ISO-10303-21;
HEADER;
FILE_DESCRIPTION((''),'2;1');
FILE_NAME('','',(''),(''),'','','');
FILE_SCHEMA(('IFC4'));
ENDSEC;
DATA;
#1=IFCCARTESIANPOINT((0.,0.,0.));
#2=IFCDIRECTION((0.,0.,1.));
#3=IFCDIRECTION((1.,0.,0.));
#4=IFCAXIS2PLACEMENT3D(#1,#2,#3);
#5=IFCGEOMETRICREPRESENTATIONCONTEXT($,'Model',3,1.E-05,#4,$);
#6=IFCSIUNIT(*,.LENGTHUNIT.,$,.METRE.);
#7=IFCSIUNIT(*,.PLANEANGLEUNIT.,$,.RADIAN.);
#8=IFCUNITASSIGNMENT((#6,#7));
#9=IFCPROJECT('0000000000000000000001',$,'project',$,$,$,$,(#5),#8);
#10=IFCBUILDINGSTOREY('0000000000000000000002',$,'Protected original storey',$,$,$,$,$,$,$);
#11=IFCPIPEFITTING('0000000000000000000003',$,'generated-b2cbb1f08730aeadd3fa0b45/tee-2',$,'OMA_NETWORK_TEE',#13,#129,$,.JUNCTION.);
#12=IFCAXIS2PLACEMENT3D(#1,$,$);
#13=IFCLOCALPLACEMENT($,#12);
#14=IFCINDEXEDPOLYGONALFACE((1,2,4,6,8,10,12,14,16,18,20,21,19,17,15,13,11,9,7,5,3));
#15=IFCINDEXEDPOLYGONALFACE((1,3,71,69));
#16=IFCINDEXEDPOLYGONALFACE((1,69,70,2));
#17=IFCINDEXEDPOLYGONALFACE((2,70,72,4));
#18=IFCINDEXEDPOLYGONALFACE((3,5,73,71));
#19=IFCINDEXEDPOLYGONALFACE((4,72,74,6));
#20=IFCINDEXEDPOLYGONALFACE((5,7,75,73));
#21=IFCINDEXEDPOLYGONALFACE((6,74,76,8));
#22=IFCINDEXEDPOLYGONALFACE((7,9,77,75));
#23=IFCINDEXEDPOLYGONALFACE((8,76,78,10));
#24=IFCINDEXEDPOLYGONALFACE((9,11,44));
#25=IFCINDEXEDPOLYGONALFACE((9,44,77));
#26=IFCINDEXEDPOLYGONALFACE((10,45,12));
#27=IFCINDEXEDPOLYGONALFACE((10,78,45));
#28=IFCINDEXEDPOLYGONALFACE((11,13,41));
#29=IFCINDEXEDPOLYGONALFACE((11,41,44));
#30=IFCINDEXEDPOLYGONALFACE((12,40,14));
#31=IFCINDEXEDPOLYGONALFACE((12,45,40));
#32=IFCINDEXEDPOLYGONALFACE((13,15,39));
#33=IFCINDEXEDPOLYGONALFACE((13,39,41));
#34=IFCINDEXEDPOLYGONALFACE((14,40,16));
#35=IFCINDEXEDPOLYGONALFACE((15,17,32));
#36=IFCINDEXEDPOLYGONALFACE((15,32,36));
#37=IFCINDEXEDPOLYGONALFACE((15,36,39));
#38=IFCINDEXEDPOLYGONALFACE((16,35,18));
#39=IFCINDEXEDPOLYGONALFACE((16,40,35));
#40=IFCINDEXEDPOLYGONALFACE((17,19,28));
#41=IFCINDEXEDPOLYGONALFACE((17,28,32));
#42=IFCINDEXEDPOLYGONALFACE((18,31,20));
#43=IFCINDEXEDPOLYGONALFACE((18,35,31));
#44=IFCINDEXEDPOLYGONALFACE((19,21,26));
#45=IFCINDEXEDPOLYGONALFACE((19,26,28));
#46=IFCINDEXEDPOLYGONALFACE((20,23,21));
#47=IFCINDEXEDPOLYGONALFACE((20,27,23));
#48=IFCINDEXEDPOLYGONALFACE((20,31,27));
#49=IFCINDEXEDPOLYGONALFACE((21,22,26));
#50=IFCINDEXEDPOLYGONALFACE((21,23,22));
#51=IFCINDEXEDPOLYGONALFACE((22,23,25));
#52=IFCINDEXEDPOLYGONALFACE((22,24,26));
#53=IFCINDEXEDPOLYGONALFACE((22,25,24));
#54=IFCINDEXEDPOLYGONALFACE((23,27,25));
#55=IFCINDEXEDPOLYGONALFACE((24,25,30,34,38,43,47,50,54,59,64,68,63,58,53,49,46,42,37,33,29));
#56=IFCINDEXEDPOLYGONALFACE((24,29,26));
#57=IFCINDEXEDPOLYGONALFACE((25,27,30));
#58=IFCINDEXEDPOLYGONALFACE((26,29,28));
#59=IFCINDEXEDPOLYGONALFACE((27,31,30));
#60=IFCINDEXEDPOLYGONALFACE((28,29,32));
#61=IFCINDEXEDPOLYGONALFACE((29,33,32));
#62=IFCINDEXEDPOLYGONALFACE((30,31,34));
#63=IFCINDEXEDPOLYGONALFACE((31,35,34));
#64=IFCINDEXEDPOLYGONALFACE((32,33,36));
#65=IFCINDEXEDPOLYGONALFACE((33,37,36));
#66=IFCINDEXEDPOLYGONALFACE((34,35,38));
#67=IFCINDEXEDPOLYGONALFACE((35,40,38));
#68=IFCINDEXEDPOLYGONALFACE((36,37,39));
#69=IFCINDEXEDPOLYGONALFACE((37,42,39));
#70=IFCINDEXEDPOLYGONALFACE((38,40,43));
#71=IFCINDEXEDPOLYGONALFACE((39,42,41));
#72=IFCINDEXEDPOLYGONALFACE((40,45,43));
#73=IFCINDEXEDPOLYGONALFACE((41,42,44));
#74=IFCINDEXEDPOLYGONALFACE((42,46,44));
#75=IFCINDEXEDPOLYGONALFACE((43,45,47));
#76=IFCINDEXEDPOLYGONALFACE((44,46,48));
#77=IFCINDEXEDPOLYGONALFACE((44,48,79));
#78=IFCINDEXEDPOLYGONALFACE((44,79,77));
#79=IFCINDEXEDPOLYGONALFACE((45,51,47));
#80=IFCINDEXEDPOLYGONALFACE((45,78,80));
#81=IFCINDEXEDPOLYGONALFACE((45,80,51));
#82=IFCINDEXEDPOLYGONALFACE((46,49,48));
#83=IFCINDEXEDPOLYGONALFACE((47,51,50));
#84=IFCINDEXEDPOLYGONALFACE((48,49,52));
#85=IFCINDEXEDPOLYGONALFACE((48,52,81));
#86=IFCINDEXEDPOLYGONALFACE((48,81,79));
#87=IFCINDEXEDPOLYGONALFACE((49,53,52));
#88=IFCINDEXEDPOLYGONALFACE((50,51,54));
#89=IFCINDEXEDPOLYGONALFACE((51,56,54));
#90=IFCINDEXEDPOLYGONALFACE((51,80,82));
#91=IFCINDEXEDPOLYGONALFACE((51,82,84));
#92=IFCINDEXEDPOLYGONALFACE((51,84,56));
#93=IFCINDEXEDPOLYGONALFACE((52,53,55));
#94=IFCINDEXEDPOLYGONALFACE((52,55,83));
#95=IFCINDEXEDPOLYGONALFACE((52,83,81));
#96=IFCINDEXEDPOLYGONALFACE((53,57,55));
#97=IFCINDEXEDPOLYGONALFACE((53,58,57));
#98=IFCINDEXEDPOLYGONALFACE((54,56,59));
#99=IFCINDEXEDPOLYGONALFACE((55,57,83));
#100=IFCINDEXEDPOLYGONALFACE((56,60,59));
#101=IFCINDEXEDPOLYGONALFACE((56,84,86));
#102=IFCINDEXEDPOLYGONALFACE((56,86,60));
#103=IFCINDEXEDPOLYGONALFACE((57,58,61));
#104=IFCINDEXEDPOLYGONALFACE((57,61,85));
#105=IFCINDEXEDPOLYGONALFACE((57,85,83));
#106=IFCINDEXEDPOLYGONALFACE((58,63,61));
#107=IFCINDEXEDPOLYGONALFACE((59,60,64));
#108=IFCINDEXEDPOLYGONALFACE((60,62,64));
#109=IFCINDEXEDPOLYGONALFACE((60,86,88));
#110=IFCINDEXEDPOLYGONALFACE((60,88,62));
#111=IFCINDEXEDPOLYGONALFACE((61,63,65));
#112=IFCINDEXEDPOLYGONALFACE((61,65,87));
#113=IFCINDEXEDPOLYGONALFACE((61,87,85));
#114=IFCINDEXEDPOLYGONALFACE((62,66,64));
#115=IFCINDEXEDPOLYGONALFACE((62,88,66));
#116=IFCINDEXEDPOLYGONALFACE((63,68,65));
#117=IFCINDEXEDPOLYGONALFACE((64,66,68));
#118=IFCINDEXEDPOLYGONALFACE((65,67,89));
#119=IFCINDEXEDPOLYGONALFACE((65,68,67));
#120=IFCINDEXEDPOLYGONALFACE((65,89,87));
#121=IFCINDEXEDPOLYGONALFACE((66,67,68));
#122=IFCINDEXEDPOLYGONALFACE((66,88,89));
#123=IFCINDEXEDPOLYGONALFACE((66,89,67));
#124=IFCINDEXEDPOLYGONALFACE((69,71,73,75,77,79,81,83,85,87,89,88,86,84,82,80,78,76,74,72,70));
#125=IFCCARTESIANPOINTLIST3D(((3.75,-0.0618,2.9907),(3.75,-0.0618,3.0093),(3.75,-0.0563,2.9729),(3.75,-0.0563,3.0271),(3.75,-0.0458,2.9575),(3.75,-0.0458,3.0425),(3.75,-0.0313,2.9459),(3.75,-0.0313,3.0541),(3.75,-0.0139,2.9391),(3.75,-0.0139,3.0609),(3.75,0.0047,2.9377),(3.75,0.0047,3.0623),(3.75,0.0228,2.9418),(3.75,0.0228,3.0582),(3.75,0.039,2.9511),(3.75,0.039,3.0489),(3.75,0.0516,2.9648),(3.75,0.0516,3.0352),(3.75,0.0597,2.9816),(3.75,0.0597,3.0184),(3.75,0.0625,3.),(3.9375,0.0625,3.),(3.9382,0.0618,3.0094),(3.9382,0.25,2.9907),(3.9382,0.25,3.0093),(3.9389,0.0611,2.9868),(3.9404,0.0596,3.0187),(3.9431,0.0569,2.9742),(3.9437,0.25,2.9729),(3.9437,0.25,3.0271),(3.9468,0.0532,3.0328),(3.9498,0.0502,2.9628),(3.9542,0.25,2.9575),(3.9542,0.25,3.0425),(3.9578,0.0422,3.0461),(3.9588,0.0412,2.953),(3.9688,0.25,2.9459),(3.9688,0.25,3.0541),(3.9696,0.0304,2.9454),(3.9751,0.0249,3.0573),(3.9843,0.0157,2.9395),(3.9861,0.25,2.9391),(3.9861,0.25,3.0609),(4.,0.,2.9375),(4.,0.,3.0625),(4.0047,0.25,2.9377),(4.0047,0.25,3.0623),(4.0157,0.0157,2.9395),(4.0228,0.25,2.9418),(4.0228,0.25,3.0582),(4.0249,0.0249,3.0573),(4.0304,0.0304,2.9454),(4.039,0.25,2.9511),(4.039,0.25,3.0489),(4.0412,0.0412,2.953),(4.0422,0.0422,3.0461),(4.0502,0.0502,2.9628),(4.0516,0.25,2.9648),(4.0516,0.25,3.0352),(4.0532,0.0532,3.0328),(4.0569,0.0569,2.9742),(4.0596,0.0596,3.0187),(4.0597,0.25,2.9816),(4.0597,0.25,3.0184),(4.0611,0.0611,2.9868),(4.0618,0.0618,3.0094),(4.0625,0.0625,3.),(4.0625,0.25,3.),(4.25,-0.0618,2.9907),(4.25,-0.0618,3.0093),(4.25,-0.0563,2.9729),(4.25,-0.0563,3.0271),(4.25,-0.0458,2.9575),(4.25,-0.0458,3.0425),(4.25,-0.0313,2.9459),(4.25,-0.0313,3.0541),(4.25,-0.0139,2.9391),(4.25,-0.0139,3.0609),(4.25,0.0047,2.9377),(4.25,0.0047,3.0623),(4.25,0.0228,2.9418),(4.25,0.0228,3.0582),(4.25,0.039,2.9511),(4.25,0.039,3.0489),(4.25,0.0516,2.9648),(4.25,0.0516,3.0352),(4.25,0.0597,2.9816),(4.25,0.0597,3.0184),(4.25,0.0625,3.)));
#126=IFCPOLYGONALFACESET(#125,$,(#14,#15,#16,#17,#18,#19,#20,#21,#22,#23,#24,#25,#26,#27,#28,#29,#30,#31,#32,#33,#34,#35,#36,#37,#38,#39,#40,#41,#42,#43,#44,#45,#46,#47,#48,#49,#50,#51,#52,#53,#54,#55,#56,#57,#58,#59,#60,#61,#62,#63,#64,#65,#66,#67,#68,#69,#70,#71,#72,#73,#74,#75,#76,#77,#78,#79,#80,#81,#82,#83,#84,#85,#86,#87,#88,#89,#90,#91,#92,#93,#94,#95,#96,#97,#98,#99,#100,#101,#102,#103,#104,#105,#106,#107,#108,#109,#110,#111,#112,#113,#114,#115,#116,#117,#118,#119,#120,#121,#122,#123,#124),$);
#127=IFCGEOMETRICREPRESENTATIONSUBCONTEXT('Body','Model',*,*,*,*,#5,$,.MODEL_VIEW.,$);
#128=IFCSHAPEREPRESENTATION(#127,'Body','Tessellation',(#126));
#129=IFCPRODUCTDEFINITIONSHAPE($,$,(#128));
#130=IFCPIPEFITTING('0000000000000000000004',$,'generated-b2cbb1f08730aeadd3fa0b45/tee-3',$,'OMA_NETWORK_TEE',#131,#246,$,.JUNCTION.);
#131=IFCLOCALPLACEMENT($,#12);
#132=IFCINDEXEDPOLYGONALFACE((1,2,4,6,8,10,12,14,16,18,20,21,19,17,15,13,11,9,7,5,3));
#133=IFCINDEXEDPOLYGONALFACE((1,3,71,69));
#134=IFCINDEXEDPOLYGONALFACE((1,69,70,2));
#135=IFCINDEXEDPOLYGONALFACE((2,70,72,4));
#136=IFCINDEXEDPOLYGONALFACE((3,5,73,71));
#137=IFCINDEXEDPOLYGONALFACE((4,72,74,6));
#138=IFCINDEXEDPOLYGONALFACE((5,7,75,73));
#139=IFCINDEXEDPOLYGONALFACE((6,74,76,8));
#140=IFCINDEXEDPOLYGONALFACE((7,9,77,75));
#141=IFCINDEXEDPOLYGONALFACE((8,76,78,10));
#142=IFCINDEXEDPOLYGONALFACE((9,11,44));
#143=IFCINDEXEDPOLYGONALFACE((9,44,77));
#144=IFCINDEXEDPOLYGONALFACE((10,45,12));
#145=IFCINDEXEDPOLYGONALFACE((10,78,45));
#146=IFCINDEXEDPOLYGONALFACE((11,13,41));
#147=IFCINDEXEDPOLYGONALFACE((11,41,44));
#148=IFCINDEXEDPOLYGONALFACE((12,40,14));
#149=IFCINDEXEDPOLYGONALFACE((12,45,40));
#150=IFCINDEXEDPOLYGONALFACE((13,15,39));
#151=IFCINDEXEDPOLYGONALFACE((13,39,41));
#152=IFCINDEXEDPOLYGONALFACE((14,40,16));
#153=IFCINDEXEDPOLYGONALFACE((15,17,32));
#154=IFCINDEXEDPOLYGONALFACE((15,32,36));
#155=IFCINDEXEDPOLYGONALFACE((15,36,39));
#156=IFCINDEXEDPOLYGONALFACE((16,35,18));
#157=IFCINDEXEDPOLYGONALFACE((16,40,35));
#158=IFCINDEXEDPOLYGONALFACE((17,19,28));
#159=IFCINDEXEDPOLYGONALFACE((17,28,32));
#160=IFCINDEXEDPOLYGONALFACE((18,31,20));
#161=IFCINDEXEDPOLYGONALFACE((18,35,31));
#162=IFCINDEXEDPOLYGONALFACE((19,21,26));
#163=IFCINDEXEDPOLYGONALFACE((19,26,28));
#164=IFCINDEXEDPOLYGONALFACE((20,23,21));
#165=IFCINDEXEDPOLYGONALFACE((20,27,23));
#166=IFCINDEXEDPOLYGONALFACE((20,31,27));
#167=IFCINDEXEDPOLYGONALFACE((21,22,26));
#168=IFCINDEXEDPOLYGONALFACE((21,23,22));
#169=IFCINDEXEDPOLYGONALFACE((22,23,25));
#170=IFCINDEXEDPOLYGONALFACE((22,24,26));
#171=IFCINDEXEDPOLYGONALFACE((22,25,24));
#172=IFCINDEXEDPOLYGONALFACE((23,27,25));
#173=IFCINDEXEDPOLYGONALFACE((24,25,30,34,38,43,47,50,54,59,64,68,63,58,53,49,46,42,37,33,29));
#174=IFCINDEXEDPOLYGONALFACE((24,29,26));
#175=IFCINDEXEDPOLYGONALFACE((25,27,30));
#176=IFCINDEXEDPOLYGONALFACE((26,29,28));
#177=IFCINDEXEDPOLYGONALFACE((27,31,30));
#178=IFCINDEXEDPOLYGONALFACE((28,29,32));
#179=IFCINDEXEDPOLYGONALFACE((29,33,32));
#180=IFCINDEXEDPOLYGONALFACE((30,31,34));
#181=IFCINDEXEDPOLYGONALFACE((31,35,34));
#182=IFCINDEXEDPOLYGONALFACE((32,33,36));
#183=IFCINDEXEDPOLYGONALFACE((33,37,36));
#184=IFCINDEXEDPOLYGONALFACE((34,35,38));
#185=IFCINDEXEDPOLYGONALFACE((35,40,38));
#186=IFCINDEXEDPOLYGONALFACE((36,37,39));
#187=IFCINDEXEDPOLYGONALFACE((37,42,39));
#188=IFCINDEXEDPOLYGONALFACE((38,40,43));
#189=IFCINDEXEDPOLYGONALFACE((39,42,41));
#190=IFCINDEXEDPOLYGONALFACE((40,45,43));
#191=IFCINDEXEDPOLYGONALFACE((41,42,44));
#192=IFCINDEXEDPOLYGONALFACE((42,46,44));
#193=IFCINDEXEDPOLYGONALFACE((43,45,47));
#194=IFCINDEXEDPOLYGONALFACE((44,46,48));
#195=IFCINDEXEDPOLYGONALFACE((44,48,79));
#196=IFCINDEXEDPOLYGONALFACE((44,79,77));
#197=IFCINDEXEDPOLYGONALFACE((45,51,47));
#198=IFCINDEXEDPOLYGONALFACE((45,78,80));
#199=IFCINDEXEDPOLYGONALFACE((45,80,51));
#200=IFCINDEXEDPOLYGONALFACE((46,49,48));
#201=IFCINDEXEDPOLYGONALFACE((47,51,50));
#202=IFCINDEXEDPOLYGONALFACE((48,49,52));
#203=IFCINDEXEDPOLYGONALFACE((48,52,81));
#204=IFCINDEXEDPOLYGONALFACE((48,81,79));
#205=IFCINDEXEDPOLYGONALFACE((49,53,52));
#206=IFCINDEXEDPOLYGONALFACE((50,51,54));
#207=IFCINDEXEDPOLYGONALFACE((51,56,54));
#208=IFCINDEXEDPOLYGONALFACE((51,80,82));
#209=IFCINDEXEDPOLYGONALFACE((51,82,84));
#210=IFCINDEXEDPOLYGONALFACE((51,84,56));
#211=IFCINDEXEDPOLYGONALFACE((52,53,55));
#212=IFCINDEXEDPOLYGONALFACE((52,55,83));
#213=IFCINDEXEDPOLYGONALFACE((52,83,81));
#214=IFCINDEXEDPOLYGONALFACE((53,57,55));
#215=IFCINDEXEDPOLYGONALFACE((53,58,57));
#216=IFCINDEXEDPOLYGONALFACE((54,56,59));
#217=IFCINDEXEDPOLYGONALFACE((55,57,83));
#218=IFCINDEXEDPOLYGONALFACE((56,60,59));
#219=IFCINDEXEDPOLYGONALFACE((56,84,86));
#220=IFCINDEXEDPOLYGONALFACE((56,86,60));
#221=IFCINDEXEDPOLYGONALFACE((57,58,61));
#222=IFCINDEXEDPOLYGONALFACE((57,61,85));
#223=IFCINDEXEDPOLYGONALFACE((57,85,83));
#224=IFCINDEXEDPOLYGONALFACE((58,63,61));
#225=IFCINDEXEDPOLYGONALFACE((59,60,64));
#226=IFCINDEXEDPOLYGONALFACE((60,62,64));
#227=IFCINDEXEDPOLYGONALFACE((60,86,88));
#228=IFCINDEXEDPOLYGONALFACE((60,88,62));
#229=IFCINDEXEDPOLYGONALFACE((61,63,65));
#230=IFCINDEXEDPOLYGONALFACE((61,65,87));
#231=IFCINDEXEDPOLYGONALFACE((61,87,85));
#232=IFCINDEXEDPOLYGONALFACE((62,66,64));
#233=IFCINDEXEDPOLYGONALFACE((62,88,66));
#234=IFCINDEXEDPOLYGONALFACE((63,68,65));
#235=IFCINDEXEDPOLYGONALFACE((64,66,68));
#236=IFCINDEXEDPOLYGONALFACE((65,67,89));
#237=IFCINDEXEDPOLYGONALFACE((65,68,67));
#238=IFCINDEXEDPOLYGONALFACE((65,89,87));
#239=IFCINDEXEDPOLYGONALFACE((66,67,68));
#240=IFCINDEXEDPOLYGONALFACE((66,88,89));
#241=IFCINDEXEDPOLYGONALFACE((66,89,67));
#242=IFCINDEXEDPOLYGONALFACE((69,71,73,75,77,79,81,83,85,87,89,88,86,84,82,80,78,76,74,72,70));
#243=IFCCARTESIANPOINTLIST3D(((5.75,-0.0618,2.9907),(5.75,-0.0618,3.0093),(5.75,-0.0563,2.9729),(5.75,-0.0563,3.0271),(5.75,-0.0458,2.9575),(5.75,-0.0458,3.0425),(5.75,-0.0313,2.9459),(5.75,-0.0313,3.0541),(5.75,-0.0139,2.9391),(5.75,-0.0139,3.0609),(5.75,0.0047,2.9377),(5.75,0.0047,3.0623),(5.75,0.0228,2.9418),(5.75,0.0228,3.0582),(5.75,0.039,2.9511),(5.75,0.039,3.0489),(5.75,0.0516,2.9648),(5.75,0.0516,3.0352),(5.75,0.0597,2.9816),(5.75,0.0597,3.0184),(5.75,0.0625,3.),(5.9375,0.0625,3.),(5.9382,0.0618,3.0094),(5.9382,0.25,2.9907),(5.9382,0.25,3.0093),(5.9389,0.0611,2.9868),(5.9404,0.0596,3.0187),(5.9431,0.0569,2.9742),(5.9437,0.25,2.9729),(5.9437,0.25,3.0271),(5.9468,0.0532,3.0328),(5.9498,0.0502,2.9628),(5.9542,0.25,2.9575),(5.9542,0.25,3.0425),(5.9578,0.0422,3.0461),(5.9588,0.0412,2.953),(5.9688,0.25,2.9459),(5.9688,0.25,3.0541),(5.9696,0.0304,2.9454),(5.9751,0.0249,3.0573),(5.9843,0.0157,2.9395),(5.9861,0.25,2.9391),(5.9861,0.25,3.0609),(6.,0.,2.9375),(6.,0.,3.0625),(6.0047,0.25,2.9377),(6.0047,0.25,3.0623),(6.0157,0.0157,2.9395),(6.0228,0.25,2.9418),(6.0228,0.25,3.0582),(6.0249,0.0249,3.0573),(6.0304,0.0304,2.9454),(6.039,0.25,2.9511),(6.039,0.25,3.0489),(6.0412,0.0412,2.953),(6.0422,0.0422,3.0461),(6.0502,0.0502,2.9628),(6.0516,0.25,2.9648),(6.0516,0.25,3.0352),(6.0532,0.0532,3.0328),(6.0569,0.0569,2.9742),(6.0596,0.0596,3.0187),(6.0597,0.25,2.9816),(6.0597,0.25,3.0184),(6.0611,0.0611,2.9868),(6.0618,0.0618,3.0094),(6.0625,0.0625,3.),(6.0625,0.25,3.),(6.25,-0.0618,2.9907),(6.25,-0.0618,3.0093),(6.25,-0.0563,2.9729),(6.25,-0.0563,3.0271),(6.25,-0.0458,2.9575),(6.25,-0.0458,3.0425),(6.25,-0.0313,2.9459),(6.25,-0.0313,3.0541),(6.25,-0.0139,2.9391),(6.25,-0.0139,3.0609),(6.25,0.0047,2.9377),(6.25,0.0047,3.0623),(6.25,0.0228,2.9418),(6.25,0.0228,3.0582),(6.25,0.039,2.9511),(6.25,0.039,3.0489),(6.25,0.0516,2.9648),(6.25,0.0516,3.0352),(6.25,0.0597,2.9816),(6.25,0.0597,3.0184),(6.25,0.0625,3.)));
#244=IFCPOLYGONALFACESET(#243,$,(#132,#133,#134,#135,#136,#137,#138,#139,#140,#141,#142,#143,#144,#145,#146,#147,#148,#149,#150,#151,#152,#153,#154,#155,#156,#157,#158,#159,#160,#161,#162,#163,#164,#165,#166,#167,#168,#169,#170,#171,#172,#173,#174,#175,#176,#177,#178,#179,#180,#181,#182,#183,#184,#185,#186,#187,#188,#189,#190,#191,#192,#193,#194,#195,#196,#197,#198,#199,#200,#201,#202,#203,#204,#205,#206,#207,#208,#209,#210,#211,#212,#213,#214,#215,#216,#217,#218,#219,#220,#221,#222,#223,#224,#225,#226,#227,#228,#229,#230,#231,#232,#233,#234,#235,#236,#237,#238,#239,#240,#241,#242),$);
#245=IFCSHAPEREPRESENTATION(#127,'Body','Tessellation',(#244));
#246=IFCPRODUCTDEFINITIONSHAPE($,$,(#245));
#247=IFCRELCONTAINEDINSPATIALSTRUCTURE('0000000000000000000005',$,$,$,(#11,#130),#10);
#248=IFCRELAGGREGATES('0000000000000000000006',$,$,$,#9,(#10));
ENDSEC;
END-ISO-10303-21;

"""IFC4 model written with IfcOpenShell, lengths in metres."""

from ifc_helpers import new_model, si_unit, frame, origin_with_axes, origin_2d, place, context, subcontext, project, spatial, circle, extrude, boolean, element, save


model = new_model("IFC4")

# Units and contexts
model_context = context("Model", 3, precision=1e-05, world=origin_with_axes())
body_context = subcontext(model_context, "Body", "Model", "MODEL_VIEW")
ifc_project = project(units=[si_unit("LENGTHUNIT", "METRE"), si_unit("PLANEANGLEUNIT", "RADIAN")], contexts=[model_context])

# Storey
storey = spatial("IfcBuildingStorey", under=ifc_project, Name="Protected original storey")

# Pipe fittings
pipe_fitting_1_placement = place(None, origin_with_axes())
element("IfcPipeFitting", 1, at=pipe_fitting_1_placement, inside=storey, Name="generated-b2cbb1f08730aeadd3fa0b45/tee-2", ObjectType="OMA_NETWORK_TEE", PredefinedType="JUNCTION", context=body_context, shape_type="CSG", body=[
    boolean("UNION", extrude(circle(Radius=0.0625, at=origin_2d()), frame((3.75, 0.0, 3.0), z_axis=(1.0, 0.0, 0.0), x_axis=(0.0, 1.0, 0.0)), (0.0, 0.0, 1.0), 0.5), extrude(circle(Radius=0.0625, at=origin_2d()), frame((4.0, 0.0, 3.0), z_axis=(0.0, 1.0, 0.0), x_axis=(1.0, 0.0, 0.0)), (0.0, 0.0, 1.0), 0.25)),
])
pipe_fitting_2_placement = place(None, origin_with_axes())
element("IfcPipeFitting", 2, at=pipe_fitting_2_placement, inside=storey, Name="generated-b2cbb1f08730aeadd3fa0b45/tee-3", ObjectType="OMA_NETWORK_TEE", PredefinedType="JUNCTION", context=body_context, shape_type="CSG", body=[
    boolean("UNION", extrude(circle(Radius=0.0625, at=origin_2d()), frame((5.75, 0.0, 3.0), z_axis=(1.0, 0.0, 0.0), x_axis=(0.0, 1.0, 0.0)), (0.0, 0.0, 1.0), 0.5), extrude(circle(Radius=0.0625, at=origin_2d()), frame((6.0, 0.0, 3.0), z_axis=(0.0, 1.0, 0.0), x_axis=(1.0, 0.0, 0.0)), (0.0, 0.0, 1.0), 0.25)),
])

save(model, "model.ifc")
